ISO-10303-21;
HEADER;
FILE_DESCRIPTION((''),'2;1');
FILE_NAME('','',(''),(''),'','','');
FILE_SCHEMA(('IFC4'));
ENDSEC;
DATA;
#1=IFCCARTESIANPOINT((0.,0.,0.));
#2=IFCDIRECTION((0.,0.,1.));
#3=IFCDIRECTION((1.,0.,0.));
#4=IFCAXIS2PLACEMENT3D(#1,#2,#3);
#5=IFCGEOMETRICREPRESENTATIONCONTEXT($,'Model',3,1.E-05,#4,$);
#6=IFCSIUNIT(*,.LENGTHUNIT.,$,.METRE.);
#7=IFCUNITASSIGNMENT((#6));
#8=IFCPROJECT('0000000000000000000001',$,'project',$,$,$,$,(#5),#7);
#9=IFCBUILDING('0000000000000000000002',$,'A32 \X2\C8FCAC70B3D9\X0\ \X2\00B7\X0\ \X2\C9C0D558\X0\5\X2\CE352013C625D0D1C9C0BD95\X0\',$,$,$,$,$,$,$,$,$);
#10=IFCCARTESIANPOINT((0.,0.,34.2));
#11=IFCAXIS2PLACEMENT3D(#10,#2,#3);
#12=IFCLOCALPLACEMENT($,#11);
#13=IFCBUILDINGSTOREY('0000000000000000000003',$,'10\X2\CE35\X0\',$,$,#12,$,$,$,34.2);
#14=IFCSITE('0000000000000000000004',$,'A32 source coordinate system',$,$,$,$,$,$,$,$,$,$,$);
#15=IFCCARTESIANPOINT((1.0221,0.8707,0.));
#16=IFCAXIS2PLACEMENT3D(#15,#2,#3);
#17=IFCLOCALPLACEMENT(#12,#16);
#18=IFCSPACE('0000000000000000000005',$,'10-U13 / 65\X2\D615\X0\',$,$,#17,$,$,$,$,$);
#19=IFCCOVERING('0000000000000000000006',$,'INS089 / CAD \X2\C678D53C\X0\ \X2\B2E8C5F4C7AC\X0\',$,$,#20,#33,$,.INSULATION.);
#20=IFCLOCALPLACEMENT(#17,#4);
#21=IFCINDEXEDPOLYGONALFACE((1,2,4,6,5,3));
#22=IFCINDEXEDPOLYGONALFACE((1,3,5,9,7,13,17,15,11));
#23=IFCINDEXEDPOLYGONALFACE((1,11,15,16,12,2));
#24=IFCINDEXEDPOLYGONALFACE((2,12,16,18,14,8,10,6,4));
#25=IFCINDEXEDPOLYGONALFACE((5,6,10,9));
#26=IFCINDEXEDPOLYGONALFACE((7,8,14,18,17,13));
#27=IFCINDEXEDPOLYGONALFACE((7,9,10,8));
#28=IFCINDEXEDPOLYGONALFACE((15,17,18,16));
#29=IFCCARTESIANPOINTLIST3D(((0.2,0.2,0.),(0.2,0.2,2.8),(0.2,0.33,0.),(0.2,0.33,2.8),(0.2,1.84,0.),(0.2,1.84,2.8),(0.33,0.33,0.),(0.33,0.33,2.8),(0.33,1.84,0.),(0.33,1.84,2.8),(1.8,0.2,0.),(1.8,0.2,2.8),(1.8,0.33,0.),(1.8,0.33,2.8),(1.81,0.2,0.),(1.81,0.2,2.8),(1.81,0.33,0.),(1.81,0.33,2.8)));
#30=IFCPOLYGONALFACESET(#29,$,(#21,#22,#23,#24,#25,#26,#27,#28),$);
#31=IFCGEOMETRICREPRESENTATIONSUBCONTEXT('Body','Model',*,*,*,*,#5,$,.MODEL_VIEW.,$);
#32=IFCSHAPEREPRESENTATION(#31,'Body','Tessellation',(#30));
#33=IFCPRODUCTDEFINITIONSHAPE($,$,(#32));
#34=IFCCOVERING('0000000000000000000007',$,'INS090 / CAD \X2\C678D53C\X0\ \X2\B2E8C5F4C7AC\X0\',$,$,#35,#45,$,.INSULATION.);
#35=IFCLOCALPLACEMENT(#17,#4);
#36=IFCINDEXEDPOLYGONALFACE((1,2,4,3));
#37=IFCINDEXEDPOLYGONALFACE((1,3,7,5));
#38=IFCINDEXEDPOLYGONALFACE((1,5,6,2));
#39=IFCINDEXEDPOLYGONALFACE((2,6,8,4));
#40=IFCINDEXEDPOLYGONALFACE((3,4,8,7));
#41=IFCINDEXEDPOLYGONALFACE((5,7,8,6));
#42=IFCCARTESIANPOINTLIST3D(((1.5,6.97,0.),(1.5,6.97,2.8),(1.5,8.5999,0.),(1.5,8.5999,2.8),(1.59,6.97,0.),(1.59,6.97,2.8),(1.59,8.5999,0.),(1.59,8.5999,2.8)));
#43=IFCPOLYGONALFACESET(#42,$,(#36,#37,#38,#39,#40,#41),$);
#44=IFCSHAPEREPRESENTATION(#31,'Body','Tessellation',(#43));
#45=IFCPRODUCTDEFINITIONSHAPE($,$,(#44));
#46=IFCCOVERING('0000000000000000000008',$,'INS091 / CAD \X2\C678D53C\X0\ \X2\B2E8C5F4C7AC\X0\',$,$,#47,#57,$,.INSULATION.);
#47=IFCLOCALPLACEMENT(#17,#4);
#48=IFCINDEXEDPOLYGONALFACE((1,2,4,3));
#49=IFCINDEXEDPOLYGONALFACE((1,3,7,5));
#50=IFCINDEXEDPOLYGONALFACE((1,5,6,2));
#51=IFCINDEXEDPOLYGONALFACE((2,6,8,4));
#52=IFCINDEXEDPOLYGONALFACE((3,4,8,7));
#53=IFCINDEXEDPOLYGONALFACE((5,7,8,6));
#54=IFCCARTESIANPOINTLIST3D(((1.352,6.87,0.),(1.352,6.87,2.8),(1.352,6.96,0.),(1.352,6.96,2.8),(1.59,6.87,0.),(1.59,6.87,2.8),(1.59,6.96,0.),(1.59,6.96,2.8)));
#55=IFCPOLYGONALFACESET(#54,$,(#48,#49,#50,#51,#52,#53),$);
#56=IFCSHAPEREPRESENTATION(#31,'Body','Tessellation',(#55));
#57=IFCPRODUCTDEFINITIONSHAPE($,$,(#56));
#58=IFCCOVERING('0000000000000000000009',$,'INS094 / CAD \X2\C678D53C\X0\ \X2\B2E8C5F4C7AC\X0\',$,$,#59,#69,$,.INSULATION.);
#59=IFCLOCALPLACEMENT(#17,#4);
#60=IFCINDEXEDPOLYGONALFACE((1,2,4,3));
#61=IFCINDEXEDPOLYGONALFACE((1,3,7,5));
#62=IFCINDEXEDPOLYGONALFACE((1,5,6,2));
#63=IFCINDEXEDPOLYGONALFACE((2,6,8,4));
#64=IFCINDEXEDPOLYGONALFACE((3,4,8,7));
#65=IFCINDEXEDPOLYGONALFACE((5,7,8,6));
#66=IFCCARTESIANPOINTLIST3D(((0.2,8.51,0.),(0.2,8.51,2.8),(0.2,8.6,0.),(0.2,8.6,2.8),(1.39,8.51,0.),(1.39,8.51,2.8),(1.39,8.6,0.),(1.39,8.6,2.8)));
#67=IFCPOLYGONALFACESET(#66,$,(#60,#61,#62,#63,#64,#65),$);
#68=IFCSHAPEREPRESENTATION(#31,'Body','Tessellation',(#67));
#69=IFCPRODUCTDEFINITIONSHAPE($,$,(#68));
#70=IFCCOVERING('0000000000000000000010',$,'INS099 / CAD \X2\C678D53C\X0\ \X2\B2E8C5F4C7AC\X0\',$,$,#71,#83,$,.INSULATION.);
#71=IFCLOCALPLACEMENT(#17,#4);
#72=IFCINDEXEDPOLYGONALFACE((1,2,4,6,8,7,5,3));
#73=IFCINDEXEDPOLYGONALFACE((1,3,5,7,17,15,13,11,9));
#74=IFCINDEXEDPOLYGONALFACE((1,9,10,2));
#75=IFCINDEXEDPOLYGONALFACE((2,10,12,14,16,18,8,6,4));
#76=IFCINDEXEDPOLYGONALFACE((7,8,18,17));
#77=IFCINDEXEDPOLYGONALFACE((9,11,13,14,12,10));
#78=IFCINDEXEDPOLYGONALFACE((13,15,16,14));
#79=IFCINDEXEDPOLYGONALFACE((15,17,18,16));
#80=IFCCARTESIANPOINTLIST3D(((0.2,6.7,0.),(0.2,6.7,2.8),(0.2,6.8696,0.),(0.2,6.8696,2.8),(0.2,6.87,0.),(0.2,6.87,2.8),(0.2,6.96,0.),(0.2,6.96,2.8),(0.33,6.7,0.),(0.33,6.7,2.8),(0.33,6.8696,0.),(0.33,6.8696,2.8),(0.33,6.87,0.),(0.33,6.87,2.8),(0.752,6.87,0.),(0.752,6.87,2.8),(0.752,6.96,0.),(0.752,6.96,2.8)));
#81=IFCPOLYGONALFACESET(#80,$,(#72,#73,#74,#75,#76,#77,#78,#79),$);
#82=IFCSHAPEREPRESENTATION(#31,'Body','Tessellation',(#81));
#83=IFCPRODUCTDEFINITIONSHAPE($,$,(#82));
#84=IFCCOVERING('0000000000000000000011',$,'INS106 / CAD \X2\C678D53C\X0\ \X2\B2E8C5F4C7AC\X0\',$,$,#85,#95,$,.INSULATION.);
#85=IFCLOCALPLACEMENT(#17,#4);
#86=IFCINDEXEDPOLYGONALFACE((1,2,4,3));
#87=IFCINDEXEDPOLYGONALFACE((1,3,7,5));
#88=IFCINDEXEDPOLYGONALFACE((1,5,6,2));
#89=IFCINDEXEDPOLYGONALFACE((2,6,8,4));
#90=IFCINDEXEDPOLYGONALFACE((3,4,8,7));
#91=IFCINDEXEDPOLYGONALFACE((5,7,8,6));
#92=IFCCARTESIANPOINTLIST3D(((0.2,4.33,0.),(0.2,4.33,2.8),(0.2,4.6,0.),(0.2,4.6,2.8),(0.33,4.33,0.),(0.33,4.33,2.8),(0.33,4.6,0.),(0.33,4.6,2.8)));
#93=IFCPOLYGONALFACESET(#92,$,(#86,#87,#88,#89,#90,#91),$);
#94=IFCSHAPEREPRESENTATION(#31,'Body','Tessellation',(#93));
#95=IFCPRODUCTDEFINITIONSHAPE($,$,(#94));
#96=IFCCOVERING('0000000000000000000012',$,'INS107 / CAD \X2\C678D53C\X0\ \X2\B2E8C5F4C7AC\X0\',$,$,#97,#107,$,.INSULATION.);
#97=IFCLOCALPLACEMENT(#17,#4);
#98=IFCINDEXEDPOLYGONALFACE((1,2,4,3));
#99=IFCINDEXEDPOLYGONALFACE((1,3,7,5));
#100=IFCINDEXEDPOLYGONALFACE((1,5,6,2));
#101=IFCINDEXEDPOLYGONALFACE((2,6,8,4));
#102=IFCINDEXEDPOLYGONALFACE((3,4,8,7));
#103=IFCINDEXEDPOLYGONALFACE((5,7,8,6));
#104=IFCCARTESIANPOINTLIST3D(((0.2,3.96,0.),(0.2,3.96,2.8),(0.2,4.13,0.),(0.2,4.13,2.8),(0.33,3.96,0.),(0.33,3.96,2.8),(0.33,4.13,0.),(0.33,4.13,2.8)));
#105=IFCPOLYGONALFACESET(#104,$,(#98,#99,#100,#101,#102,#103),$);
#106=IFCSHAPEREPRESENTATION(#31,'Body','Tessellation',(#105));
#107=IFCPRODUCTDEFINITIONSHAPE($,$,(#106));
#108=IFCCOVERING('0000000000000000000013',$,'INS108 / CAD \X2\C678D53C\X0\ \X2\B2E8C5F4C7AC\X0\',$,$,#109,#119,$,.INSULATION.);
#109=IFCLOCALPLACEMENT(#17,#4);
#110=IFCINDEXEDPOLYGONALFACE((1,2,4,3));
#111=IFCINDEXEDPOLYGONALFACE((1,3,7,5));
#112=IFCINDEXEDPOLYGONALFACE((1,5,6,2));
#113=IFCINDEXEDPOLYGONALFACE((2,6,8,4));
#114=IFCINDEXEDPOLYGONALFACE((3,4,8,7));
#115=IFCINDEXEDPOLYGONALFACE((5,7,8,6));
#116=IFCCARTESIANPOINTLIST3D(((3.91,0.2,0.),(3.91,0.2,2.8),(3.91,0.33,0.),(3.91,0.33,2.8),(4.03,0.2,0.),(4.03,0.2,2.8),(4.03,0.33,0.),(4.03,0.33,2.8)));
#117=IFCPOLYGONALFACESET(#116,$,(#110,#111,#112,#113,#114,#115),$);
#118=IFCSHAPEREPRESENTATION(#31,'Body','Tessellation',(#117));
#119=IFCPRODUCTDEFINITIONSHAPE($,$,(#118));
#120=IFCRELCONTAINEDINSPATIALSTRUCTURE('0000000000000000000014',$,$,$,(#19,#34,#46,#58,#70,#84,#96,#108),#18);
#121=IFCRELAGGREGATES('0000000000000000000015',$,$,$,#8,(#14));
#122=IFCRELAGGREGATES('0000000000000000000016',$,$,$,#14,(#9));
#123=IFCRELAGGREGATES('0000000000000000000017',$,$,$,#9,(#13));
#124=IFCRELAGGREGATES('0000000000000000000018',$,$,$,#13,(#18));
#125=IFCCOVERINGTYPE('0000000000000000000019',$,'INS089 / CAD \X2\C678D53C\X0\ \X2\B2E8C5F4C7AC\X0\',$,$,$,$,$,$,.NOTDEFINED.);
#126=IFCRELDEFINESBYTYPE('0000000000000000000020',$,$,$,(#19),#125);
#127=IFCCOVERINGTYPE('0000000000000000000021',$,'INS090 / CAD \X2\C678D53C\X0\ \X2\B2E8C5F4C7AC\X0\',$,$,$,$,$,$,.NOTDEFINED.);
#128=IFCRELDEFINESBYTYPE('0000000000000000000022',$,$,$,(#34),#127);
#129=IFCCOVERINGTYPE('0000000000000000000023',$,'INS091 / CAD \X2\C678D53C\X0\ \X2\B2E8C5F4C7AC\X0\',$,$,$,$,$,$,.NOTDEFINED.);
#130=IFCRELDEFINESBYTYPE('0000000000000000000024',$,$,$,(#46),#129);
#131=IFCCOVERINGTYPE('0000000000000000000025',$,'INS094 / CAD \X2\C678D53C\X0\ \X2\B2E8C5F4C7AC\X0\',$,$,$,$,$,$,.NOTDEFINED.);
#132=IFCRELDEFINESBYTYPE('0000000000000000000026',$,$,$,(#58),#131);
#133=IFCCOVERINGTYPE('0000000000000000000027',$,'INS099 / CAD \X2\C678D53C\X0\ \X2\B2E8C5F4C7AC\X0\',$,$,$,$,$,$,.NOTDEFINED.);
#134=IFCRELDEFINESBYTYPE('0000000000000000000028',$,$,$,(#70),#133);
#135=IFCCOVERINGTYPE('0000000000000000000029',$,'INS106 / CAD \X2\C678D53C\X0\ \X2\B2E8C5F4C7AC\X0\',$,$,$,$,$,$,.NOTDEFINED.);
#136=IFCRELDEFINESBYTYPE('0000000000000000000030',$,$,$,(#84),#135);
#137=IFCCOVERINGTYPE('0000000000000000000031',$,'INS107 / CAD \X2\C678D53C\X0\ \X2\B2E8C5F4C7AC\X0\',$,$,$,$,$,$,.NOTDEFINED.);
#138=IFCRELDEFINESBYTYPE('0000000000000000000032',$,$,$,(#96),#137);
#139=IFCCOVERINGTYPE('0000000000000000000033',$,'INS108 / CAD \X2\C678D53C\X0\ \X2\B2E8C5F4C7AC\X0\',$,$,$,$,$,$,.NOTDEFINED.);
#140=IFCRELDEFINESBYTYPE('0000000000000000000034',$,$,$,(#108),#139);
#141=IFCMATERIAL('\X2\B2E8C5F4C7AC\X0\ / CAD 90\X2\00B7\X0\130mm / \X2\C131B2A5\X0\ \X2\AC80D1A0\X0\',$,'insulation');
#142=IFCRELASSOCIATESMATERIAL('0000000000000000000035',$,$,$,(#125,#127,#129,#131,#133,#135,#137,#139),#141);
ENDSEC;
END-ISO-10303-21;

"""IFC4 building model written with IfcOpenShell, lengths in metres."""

from ifc_helpers import new_model, si_unit, frame, origin, origin_with_axes, place, context, subcontext, project, spatial, polyline, outline, extrude, source, transform, mapped, material, type_object, type_shapes, element, save


model = new_model("IFC4")

# Units and contexts
model_context = context("Model", 3, precision=1e-05, world=origin_with_axes())
body_context = subcontext(model_context, "Body", "Model", "MODEL_VIEW")
ifc_project = project(units=[si_unit("LENGTHUNIT", "METRE")], contexts=[model_context])

# Site, building, storey
site = spatial("IfcSite", under=ifc_project, Name="A32 source coordinate system")
building = spatial("IfcBuilding", under=site, Name="A32 주거동 · 지하5층–옥탑지붕")
storey_placement = place(None, frame((0.0, 0.0, 34.2), z_axis=(0.0, 0.0, 1.0), x_axis=(1.0, 0.0, 0.0)))
storey = spatial("IfcBuildingStorey", under=building, at=storey_placement, Name="10층", Elevation=34.2)

# Shared definitions
space_placement = place(storey_placement, frame((1.0221, 0.8707, 0.0), z_axis=(0.0, 0.0, 1.0), x_axis=(1.0, 0.0, 0.0)))
space = spatial("IfcSpace", under=storey, at=space_placement, Name="10-U13 / 65형")

# Coverings
ifc_material = material(Name="단열재 / CAD 90·130mm / 성능 검토", Category="insulation")
covering_type_1 = type_object("IfcCoveringType", Name="INS089 / CAD 외피 단열재", PredefinedType="NOTDEFINED", material=ifc_material)
shared_shape_1 = source(origin(), body_context, "Body", "SweptSolid", [
    extrude(outline(polyline([(0.2, 0.33), (0.2, 1.84), (0.33, 1.84), (0.33, 0.33), (1.8, 0.33), (1.81, 0.33), (1.81, 0.2), (1.8, 0.2), (0.2, 0.2), (0.2, 0.33)])), origin(), (0.0, 0.0, 1.0), 2.8),
])
type_shapes(covering_type_1, [shared_shape_1])
covering_1_placement = place(space_placement, origin_with_axes())
element("IfcCovering", 1, at=covering_1_placement, inside=space, type_object=covering_type_1, Name="INS089 / CAD 외피 단열재", PredefinedType="INSULATION", context=body_context, shape_type="MappedRepresentation", body=[
    mapped(shared_shape_1, transform((0.0, 0.0, 0.0), scale=1.0)),
])
covering_type_2 = type_object("IfcCoveringType", Name="INS090 / CAD 외피 단열재", PredefinedType="NOTDEFINED", material=ifc_material)
shared_shape_2 = source(origin(), body_context, "Body", "SweptSolid", [
    extrude(outline(polyline([(1.59, 6.97), (1.5, 6.97), (1.5, 8.5999), (1.59, 8.5999), (1.59, 6.97)])), origin(), (0.0, 0.0, 1.0), 2.8),
])
type_shapes(covering_type_2, [shared_shape_2])
covering_2_placement = place(space_placement, origin_with_axes())
element("IfcCovering", 2, at=covering_2_placement, inside=space, type_object=covering_type_2, Name="INS090 / CAD 외피 단열재", PredefinedType="INSULATION", context=body_context, shape_type="MappedRepresentation", body=[
    mapped(shared_shape_2, transform((0.0, 0.0, 0.0), scale=1.0)),
])
covering_type_3 = type_object("IfcCoveringType", Name="INS091 / CAD 외피 단열재", PredefinedType="NOTDEFINED", material=ifc_material)
shared_shape_3 = source(origin(), body_context, "Body", "SweptSolid", [
    extrude(outline(polyline([(1.59, 6.96), (1.59, 6.87), (1.352, 6.87), (1.352, 6.96), (1.59, 6.96)])), origin(), (0.0, 0.0, 1.0), 2.8),
])
type_shapes(covering_type_3, [shared_shape_3])
covering_3_placement = place(space_placement, origin_with_axes())
element("IfcCovering", 3, at=covering_3_placement, inside=space, type_object=covering_type_3, Name="INS091 / CAD 외피 단열재", PredefinedType="INSULATION", context=body_context, shape_type="MappedRepresentation", body=[
    mapped(shared_shape_3, transform((0.0, 0.0, 0.0), scale=1.0)),
])
covering_type_4 = type_object("IfcCoveringType", Name="INS094 / CAD 외피 단열재", PredefinedType="NOTDEFINED", material=ifc_material)
shared_shape_4 = source(origin(), body_context, "Body", "SweptSolid", [
    extrude(outline(polyline([(1.39, 8.51), (0.2, 8.51), (0.2, 8.6), (1.39, 8.6), (1.39, 8.51)])), origin(), (0.0, 0.0, 1.0), 2.8),
])
type_shapes(covering_type_4, [shared_shape_4])
covering_4_placement = place(space_placement, origin_with_axes())
element("IfcCovering", 4, at=covering_4_placement, inside=space, type_object=covering_type_4, Name="INS094 / CAD 외피 단열재", PredefinedType="INSULATION", context=body_context, shape_type="MappedRepresentation", body=[
    mapped(shared_shape_4, transform((0.0, 0.0, 0.0), scale=1.0)),
])
covering_type_5 = type_object("IfcCoveringType", Name="INS099 / CAD 외피 단열재", PredefinedType="NOTDEFINED", material=ifc_material)
shared_shape_5 = source(origin(), body_context, "Body", "SweptSolid", [
    extrude(outline(polyline([(0.2, 6.8696), (0.2, 6.87), (0.2, 6.96), (0.752, 6.96), (0.752, 6.87), (0.33, 6.87), (0.33, 6.8696), (0.33, 6.7), (0.2, 6.7), (0.2, 6.8696)])), origin(), (0.0, 0.0, 1.0), 2.8),
])
type_shapes(covering_type_5, [shared_shape_5])
covering_5_placement = place(space_placement, origin_with_axes())
element("IfcCovering", 5, at=covering_5_placement, inside=space, type_object=covering_type_5, Name="INS099 / CAD 외피 단열재", PredefinedType="INSULATION", context=body_context, shape_type="MappedRepresentation", body=[
    mapped(shared_shape_5, transform((0.0, 0.0, 0.0), scale=1.0)),
])
covering_type_6 = type_object("IfcCoveringType", Name="INS106 / CAD 외피 단열재", PredefinedType="NOTDEFINED", material=ifc_material)
shared_shape_6 = source(origin(), body_context, "Body", "SweptSolid", [
    extrude(outline(polyline([(0.33, 4.6), (0.33, 4.33), (0.2, 4.33), (0.2, 4.6), (0.33, 4.6)])), origin(), (0.0, 0.0, 1.0), 2.8),
])
type_shapes(covering_type_6, [shared_shape_6])
covering_6_placement = place(space_placement, origin_with_axes())
element("IfcCovering", 6, at=covering_6_placement, inside=space, type_object=covering_type_6, Name="INS106 / CAD 외피 단열재", PredefinedType="INSULATION", context=body_context, shape_type="MappedRepresentation", body=[
    mapped(shared_shape_6, transform((0.0, 0.0, 0.0), scale=1.0)),
])
covering_type_7 = type_object("IfcCoveringType", Name="INS107 / CAD 외피 단열재", PredefinedType="NOTDEFINED", material=ifc_material)
shared_shape_7 = source(origin(), body_context, "Body", "SweptSolid", [
    extrude(outline(polyline([(0.33, 3.96), (0.2, 3.96), (0.2, 4.13), (0.33, 4.13), (0.33, 3.96)])), origin(), (0.0, 0.0, 1.0), 2.8),
])
type_shapes(covering_type_7, [shared_shape_7])
covering_7_placement = place(space_placement, origin_with_axes())
element("IfcCovering", 7, at=covering_7_placement, inside=space, type_object=covering_type_7, Name="INS107 / CAD 외피 단열재", PredefinedType="INSULATION", context=body_context, shape_type="MappedRepresentation", body=[
    mapped(shared_shape_7, transform((0.0, 0.0, 0.0), scale=1.0)),
])
covering_type_8 = type_object("IfcCoveringType", Name="INS108 / CAD 외피 단열재", PredefinedType="NOTDEFINED", material=ifc_material)
shared_shape_8 = source(origin(), body_context, "Body", "SweptSolid", [
    extrude(outline(polyline([(4.03, 0.2), (3.91, 0.2), (3.91, 0.33), (4.03, 0.33), (4.03, 0.2)])), origin(), (0.0, 0.0, 1.0), 2.8),
])
type_shapes(covering_type_8, [shared_shape_8])
covering_8_placement = place(space_placement, origin_with_axes())
element("IfcCovering", 8, at=covering_8_placement, inside=space, type_object=covering_type_8, Name="INS108 / CAD 외피 단열재", PredefinedType="INSULATION", context=body_context, shape_type="MappedRepresentation", body=[
    mapped(shared_shape_8, transform((0.0, 0.0, 0.0), scale=1.0)),
])

save(model, "model.ifc")
